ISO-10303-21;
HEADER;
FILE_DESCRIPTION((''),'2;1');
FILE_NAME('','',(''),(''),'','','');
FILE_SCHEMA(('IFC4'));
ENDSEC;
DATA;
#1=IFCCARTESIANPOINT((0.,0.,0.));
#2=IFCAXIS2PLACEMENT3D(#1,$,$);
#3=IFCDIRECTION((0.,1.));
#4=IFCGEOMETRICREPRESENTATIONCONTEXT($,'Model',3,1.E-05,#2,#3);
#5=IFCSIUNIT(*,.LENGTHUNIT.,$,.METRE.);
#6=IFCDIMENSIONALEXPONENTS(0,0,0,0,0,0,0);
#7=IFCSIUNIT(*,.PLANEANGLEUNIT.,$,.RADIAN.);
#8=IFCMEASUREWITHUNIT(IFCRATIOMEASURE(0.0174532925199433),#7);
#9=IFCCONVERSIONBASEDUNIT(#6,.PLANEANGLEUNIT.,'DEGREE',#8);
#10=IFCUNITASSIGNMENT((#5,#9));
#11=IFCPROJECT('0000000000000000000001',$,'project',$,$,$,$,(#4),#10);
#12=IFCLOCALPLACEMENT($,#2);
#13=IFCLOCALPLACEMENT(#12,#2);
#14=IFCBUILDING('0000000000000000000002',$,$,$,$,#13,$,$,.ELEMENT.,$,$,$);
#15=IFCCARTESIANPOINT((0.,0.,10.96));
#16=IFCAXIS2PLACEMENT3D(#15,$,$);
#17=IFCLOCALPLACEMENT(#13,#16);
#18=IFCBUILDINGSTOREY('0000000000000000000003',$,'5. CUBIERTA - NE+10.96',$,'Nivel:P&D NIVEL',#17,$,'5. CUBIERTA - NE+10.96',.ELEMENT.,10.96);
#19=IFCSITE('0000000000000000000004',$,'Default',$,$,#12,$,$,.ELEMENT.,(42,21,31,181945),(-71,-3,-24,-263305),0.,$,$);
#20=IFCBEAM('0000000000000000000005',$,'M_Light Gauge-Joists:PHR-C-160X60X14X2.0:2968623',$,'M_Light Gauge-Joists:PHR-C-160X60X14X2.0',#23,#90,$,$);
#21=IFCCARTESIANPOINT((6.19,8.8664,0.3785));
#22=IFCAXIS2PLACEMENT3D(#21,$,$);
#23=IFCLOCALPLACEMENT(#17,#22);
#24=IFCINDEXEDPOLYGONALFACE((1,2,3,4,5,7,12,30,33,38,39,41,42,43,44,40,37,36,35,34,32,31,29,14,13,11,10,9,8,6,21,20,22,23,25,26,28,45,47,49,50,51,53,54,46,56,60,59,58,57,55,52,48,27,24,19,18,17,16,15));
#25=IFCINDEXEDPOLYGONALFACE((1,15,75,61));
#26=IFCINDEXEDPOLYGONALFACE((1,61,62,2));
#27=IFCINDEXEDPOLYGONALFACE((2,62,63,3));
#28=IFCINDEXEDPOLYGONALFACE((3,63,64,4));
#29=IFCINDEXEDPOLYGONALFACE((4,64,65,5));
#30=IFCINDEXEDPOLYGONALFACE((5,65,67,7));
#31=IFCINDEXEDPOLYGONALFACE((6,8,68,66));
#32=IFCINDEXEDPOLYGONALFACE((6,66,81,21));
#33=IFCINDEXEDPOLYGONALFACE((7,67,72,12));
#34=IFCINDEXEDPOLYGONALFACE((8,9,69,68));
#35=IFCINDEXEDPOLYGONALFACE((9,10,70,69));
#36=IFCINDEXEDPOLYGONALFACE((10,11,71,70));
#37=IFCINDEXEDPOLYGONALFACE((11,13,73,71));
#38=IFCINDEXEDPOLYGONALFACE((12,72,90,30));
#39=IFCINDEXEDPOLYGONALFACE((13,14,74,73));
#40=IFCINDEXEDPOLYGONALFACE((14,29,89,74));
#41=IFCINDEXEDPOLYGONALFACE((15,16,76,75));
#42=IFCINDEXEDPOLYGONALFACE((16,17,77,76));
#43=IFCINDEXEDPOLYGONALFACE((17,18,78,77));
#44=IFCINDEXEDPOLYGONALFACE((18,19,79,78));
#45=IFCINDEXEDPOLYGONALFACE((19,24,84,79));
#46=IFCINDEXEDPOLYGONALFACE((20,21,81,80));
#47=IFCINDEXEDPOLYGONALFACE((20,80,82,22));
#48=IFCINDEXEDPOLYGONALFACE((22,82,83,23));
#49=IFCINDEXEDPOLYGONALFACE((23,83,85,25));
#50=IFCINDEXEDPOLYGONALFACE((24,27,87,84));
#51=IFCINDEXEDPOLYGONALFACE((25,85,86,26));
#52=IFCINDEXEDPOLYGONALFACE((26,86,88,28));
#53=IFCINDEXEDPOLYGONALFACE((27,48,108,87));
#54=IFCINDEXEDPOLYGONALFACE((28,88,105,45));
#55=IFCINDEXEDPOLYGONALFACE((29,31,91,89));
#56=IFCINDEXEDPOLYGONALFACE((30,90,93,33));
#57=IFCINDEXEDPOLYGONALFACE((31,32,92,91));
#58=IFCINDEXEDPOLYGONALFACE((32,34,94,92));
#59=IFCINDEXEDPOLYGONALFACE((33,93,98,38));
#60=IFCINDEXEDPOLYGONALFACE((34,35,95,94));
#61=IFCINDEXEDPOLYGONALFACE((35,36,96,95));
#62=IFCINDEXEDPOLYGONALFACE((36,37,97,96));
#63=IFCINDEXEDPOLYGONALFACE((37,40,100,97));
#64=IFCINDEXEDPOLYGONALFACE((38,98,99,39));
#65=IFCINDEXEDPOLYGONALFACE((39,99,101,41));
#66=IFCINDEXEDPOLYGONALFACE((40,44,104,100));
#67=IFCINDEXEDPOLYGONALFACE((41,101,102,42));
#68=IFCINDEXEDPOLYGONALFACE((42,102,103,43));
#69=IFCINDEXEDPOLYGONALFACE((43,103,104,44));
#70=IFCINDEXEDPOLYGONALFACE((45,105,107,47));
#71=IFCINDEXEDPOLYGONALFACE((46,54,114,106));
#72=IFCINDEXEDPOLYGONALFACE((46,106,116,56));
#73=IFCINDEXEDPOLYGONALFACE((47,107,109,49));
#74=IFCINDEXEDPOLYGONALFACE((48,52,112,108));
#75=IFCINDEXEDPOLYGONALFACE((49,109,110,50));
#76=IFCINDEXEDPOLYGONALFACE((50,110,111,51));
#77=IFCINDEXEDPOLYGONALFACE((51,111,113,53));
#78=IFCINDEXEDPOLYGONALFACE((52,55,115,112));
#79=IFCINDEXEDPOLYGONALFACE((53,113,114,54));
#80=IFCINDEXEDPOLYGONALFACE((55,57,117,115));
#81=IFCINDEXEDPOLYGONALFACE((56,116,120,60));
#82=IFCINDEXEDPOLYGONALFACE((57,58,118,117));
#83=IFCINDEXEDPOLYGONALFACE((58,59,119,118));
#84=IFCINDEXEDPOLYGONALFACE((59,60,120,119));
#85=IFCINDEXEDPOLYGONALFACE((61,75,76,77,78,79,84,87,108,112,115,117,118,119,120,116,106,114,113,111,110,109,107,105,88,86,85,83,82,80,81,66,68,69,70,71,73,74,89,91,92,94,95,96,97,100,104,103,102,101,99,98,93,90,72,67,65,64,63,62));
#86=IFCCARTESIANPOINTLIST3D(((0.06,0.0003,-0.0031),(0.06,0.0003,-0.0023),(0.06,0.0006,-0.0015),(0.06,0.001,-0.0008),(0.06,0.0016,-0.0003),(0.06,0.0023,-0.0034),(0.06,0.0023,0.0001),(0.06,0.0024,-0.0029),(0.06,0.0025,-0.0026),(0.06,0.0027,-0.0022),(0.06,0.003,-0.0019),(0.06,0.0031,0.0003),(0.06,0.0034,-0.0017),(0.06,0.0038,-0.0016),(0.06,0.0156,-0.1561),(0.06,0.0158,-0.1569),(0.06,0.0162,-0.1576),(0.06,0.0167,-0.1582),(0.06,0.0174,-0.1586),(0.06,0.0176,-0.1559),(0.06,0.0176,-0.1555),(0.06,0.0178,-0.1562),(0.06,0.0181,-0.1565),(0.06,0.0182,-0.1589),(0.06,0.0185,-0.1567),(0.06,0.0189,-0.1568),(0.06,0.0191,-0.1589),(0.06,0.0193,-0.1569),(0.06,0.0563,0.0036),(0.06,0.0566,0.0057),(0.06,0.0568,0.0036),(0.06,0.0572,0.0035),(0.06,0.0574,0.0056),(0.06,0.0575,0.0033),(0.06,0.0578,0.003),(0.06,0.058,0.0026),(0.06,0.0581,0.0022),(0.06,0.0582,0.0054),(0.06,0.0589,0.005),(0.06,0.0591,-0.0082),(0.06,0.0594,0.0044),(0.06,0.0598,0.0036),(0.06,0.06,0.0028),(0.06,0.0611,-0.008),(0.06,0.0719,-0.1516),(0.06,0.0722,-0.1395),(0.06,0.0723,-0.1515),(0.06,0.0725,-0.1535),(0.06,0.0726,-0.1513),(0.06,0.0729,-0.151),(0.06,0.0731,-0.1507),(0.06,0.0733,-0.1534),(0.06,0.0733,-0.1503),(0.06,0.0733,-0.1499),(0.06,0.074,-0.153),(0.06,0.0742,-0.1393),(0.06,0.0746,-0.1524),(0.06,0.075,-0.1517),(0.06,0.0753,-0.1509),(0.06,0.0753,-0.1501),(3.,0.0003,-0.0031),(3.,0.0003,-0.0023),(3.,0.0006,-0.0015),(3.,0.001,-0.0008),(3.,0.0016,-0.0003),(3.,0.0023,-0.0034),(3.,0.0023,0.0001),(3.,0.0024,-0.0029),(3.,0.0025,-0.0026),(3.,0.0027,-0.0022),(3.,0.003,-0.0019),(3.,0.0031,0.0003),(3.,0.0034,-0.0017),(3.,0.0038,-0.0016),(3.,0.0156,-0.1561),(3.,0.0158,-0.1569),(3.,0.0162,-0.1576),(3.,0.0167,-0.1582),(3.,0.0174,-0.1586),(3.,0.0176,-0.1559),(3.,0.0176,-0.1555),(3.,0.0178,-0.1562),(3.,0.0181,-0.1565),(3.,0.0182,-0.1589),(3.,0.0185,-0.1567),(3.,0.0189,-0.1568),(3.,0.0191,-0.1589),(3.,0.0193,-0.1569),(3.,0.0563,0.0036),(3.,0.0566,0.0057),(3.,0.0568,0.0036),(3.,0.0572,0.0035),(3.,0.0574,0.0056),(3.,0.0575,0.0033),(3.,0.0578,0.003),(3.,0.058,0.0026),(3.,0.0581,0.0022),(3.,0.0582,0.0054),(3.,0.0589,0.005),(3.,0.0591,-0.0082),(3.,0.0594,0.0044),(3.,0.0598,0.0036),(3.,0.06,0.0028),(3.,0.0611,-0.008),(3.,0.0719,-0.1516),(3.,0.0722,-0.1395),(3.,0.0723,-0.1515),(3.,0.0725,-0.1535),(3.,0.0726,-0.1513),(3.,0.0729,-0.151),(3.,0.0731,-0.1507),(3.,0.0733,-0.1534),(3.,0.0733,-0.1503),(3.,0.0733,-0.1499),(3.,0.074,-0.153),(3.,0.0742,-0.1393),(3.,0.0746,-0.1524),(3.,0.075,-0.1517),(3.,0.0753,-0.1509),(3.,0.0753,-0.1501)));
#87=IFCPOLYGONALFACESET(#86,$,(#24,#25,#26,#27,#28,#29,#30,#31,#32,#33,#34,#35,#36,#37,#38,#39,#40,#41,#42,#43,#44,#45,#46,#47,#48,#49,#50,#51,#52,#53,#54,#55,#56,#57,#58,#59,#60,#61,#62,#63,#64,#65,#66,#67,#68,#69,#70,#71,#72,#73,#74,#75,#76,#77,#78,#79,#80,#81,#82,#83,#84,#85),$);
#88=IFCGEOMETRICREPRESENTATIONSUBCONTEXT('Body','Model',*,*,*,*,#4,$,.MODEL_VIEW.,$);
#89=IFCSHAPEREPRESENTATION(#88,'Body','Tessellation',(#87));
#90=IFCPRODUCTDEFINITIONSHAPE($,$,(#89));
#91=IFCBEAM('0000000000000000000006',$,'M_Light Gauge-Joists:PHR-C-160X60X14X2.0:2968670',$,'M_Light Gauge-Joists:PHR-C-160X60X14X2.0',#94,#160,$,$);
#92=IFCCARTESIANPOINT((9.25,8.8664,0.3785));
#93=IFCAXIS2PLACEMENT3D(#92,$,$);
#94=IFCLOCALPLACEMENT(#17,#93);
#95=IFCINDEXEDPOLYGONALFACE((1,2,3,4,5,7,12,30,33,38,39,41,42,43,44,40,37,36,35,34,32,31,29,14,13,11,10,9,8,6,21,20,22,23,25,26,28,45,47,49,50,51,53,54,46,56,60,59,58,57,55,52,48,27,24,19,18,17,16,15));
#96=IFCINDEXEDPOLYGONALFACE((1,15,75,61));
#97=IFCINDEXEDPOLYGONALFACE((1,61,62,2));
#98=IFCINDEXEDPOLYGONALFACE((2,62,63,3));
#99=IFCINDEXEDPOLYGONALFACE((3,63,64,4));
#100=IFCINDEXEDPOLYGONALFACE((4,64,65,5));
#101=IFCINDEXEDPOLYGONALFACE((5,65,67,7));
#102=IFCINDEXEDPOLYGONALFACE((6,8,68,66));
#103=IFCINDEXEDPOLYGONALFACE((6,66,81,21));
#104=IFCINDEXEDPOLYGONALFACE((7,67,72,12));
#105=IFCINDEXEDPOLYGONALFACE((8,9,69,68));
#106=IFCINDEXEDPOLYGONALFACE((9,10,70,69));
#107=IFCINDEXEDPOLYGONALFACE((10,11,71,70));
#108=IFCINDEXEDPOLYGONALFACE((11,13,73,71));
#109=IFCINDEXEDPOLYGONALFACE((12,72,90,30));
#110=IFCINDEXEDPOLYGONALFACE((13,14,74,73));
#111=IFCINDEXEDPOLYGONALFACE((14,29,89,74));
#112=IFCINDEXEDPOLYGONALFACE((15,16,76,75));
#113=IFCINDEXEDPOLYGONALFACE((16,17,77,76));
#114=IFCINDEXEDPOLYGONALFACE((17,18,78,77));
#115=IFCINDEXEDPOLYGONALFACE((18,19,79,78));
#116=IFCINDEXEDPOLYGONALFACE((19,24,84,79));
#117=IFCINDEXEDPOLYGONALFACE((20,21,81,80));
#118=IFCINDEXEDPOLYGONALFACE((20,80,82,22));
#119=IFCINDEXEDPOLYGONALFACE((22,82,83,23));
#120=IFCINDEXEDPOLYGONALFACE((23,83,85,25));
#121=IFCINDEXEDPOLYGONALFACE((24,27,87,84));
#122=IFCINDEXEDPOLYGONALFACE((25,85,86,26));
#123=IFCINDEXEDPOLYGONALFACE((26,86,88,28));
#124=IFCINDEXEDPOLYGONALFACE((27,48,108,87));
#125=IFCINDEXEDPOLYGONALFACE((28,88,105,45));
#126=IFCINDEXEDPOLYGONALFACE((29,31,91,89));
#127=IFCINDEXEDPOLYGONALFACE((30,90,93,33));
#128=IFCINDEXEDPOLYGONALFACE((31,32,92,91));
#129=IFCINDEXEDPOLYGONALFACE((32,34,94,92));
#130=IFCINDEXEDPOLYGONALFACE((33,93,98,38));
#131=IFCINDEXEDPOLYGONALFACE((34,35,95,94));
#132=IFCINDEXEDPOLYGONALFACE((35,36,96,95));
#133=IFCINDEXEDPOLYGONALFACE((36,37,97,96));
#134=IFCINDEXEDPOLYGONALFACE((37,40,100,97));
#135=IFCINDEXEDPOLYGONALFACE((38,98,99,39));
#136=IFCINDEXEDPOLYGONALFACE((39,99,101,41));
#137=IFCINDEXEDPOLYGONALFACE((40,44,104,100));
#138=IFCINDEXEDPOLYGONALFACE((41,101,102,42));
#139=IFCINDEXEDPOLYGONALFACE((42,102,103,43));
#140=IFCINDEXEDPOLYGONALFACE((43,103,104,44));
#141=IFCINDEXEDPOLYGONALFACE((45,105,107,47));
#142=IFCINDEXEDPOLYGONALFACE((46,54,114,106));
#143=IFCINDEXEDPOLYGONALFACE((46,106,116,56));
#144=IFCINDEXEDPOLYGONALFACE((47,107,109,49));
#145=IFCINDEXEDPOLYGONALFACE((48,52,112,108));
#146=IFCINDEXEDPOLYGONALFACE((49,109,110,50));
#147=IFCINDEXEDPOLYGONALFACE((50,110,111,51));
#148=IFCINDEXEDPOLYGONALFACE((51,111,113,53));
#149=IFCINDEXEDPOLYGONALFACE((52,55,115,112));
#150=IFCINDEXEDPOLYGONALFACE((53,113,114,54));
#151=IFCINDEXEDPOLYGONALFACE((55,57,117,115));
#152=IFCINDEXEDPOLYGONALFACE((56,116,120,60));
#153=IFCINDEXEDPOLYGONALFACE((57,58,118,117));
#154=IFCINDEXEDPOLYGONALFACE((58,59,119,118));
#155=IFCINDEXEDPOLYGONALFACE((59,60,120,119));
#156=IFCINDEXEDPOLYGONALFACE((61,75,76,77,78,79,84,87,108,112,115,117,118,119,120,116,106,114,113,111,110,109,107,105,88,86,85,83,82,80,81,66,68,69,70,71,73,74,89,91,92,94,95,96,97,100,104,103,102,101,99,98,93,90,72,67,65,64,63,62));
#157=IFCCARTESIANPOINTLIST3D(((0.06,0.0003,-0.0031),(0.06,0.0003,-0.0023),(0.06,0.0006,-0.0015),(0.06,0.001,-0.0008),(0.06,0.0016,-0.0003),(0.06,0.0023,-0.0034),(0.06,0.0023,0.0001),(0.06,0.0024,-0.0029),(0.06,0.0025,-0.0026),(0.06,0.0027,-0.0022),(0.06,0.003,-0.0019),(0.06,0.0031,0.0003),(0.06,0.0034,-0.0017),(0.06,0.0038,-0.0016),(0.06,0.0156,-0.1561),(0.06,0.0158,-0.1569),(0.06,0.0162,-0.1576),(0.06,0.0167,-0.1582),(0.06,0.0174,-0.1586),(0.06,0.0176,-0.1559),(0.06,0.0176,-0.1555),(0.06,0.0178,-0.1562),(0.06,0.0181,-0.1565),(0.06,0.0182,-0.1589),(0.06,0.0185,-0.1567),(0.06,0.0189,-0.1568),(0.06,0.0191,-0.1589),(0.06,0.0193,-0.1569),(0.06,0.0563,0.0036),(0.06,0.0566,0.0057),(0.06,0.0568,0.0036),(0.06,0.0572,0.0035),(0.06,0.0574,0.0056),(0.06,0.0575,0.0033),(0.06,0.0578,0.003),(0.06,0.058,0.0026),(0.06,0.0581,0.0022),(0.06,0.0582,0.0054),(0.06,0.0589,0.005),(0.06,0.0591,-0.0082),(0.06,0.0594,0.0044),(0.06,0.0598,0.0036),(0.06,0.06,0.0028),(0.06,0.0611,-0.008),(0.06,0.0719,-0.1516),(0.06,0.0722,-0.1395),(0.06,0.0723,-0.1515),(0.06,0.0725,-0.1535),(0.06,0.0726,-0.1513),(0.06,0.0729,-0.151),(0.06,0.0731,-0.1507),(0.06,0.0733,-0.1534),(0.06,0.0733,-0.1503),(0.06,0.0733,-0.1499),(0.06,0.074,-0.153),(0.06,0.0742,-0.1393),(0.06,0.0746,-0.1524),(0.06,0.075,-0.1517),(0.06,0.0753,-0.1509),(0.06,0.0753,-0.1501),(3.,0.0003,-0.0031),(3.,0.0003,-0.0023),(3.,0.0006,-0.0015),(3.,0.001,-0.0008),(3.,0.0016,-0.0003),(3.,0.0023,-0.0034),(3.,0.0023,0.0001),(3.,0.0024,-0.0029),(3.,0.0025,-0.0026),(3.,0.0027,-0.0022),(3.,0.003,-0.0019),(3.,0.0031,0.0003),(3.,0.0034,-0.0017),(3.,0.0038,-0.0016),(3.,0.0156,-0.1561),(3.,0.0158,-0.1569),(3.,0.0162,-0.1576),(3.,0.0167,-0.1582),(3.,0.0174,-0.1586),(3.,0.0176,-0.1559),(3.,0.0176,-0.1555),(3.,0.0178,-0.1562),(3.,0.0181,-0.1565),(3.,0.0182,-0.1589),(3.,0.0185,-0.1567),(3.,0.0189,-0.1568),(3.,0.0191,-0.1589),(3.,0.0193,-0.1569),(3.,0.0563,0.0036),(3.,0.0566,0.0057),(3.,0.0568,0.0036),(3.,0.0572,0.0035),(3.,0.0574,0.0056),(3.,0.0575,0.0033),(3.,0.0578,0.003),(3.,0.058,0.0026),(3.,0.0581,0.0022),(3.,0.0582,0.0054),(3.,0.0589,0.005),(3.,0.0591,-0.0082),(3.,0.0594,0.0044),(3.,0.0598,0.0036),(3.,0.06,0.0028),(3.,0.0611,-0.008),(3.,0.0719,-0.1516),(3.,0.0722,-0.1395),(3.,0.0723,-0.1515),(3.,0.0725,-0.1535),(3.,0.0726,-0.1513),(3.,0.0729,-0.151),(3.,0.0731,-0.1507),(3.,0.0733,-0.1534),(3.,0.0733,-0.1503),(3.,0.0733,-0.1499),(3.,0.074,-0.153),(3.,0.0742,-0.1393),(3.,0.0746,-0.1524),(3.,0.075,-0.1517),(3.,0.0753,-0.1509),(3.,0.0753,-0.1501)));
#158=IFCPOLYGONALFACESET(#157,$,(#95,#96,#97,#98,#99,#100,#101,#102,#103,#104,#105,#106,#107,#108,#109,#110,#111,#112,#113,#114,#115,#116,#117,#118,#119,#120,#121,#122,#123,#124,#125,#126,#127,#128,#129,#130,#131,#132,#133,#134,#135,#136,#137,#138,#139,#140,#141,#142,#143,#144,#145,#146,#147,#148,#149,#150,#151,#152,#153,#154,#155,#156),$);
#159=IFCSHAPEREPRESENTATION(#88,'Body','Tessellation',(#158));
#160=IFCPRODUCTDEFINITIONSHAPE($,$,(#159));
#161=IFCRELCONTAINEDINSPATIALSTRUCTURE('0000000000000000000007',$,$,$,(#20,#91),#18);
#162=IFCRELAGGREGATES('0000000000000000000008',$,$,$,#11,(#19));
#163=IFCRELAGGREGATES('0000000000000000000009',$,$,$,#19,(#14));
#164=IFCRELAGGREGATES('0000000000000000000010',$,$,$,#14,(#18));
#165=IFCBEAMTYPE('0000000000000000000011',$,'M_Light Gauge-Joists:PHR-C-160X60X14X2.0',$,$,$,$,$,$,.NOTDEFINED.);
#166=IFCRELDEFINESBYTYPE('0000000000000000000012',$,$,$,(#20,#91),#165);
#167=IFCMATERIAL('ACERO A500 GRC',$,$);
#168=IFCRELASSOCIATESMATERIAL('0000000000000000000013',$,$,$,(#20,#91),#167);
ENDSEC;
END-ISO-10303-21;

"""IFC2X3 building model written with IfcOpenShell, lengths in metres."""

from ifc_helpers import new_model, entity, si_unit, converted_unit, direction, frame, frame_2d, origin, place, context, subcontext, project, spatial, polyline, circle_curve, parameter, trimmed, segment, composite_curve, outline, extrude, material, type_object, element, save


model = new_model("IFC2X3")

# Units and contexts
model_context = context("Model", 3, precision=1e-05, world=origin(), true_north=direction((0.0, 1.0)))
body_context = subcontext(model_context, "Body", "Model", "MODEL_VIEW")
ifc_project = project(units=[si_unit("LENGTHUNIT", "METRE"), converted_unit("PLANEANGLEUNIT", "DEGREE", entity("IfcRatioMeasure", 0.0174532925199433), si_unit("PLANEANGLEUNIT", "RADIAN"), dimensions=[0, 0, 0, 0, 0, 0, 0])], contexts=[model_context])

# Site, building, storey
site_placement = place(None, origin())
site = spatial("IfcSite", under=ifc_project, at=site_placement, Name="Default", CompositionType="ELEMENT", RefLatitude=(42, 21, 31, 181945), RefLongitude=(-71, -3, -24, -263305), RefElevation=0.0)
building_placement = place(site_placement, origin())
building = spatial("IfcBuilding", under=site, at=building_placement, CompositionType="ELEMENT")
storey_placement = place(building_placement, frame((0.0, 0.0, 10.96)))
storey = spatial("IfcBuildingStorey", under=building, at=storey_placement, Name="5. CUBIERTA - NE+10.96", ObjectType="Nivel:P&D NIVEL", LongName="5. CUBIERTA - NE+10.96", CompositionType="ELEMENT", Elevation=10.96)

# Beams
ifc_material_1 = material(Name="ACERO A500 GRC")
beam_type_1 = type_object("IfcBeamType", Name="M_Light Gauge-Joists:PHR-C-160X60X14X2.0", PredefinedType="NOTDEFINED")
beam_1_placement = place(storey_placement, frame((6.19, 8.8664, 0.3785)))
element("IfcBeam", 1, at=beam_1_placement, inside=storey, type_object=beam_type_1, material=ifc_material_1, Name="M_Light Gauge-Joists:PHR-C-160X60X14X2.0:2968623", ObjectType="M_Light Gauge-Joists:PHR-C-160X60X14X2.0", context=body_context, shape_type="SweptSolid", body=[
    extrude(outline(composite_curve([segment(trimmed(circle_curve(frame_2d((-0.0764, -0.0322), x_axis=(-1.0, 0.0)), 0.0016), [parameter(0.0)], [parameter(90.0)], True, "PARAMETER"), False, "CONTINUOUS"), segment(polyline([(-0.078, -0.0322), (-0.078, 0.0206)]), True, "CONTINUOUS"), segment(trimmed(circle_curve(frame_2d((-0.0764, 0.0206), x_axis=(0.0, 1.0)), 0.0016), [parameter(0.0)], [parameter(90.0)], True, "PARAMETER"), False, "CONTINUOUS"), segment(polyline([(-0.0764, 0.0222), (-0.066, 0.0222)]), True, "CONTINUOUS"), segment(polyline([(-0.066, 0.0222), (-0.066, 0.0242)]), True, "CONTINUOUS"), segment(polyline([(-0.066, 0.0242), (-0.0768, 0.0242)]), True, "CONTINUOUS"), segment(trimmed(circle_curve(frame_2d((-0.0768, 0.021), x_axis=(-1.0, 0.0)), 0.0032), [parameter(270.0)], [parameter(0.0)], True, "PARAMETER"), True, "CONTINUOUS"), segment(polyline([(-0.08, 0.021), (-0.08, -0.0326)]), True, "CONTINUOUS"), segment(trimmed(circle_curve(frame_2d((-0.0768, -0.0326), x_axis=(0.0, -1.0)), 0.0032), [parameter(270.0)], [parameter(0.0)], True, "PARAMETER"), True, "CONTINUOUS"), segment(polyline([(-0.0768, -0.0358), (0.0768, -0.0358)]), True, "CONTINUOUS"), segment(trimmed(circle_curve(frame_2d((0.0768, -0.0326), x_axis=(1.0, 0.0)), 0.0032), [parameter(270.0)], [parameter(0.0)], True, "PARAMETER"), True, "CONTINUOUS"), segment(polyline([(0.08, -0.0326), (0.08, 0.021)]), True, "CONTINUOUS"), segment(trimmed(circle_curve(frame_2d((0.0768, 0.021), x_axis=(0.0, 1.0)), 0.0032), [parameter(270.0)], [parameter(0.0)], True, "PARAMETER"), True, "CONTINUOUS"), segment(polyline([(0.0768, 0.0242), (0.066, 0.0242)]), True, "CONTINUOUS"), segment(polyline([(0.066, 0.0242), (0.066, 0.0222)]), True, "CONTINUOUS"), segment(polyline([(0.066, 0.0222), (0.0764, 0.0222)]), True, "CONTINUOUS"), segment(trimmed(circle_curve(frame_2d((0.0764, 0.0206), x_axis=(1.0, 0.0)), 0.0016), [parameter(0.0)], [parameter(90.0)], True, "PARAMETER"), False, "CONTINUOUS"), segment(polyline([(0.078, 0.0206), (0.078, -0.0322)]), True, "CONTINUOUS"), segment(trimmed(circle_curve(frame_2d((0.0764, -0.0322), x_axis=(0.0, -1.0)), 0.0016), [parameter(0.0)], [parameter(90.0)], True, "PARAMETER"), False, "CONTINUOUS"), segment(polyline([(0.0764, -0.0338), (-0.0764, -0.0338)]), True, "CONTINUOUS")], self_intersect=False)), frame((0.06, 0.0436, -0.076), z_axis=(-1.0, 0.0, 0.0), x_axis=(0.0, -0.099504, 0.995037)), (0.0, 0.0, -1.0), 2.94),
])
beam_2_placement = place(storey_placement, frame((9.25, 8.8664, 0.3785)))
element("IfcBeam", 2, at=beam_2_placement, inside=storey, type_object=beam_type_1, material=ifc_material_1, Name="M_Light Gauge-Joists:PHR-C-160X60X14X2.0:2968670", ObjectType="M_Light Gauge-Joists:PHR-C-160X60X14X2.0", context=body_context, shape_type="SweptSolid", body=[
    extrude(outline(composite_curve([segment(trimmed(circle_curve(frame_2d((-0.0764, -0.0322), x_axis=(-1.0, 0.0)), 0.0016), [parameter(0.0)], [parameter(90.0)], True, "PARAMETER"), False, "CONTINUOUS"), segment(polyline([(-0.078, -0.0322), (-0.078, 0.0206)]), True, "CONTINUOUS"), segment(trimmed(circle_curve(frame_2d((-0.0764, 0.0206), x_axis=(0.0, 1.0)), 0.0016), [parameter(0.0)], [parameter(90.0)], True, "PARAMETER"), False, "CONTINUOUS"), segment(polyline([(-0.0764, 0.0222), (-0.066, 0.0222)]), True, "CONTINUOUS"), segment(polyline([(-0.066, 0.0222), (-0.066, 0.0242)]), True, "CONTINUOUS"), segment(polyline([(-0.066, 0.0242), (-0.0768, 0.0242)]), True, "CONTINUOUS"), segment(trimmed(circle_curve(frame_2d((-0.0768, 0.021), x_axis=(-1.0, 0.0)), 0.0032), [parameter(270.0)], [parameter(0.0)], True, "PARAMETER"), True, "CONTINUOUS"), segment(polyline([(-0.08, 0.021), (-0.08, -0.0326)]), True, "CONTINUOUS"), segment(trimmed(circle_curve(frame_2d((-0.0768, -0.0326), x_axis=(0.0, -1.0)), 0.0032), [parameter(270.0)], [parameter(0.0)], True, "PARAMETER"), True, "CONTINUOUS"), segment(polyline([(-0.0768, -0.0358), (0.0768, -0.0358)]), True, "CONTINUOUS"), segment(trimmed(circle_curve(frame_2d((0.0768, -0.0326), x_axis=(1.0, 0.0)), 0.0032), [parameter(270.0)], [parameter(0.0)], True, "PARAMETER"), True, "CONTINUOUS"), segment(polyline([(0.08, -0.0326), (0.08, 0.021)]), True, "CONTINUOUS"), segment(trimmed(circle_curve(frame_2d((0.0768, 0.021), x_axis=(0.0, 1.0)), 0.0032), [parameter(270.0)], [parameter(0.0)], True, "PARAMETER"), True, "CONTINUOUS"), segment(polyline([(0.0768, 0.0242), (0.066, 0.0242)]), True, "CONTINUOUS"), segment(polyline([(0.066, 0.0242), (0.066, 0.0222)]), True, "CONTINUOUS"), segment(polyline([(0.066, 0.0222), (0.0764, 0.0222)]), True, "CONTINUOUS"), segment(trimmed(circle_curve(frame_2d((0.0764, 0.0206), x_axis=(1.0, 0.0)), 0.0016), [parameter(0.0)], [parameter(90.0)], True, "PARAMETER"), False, "CONTINUOUS"), segment(polyline([(0.078, 0.0206), (0.078, -0.0322)]), True, "CONTINUOUS"), segment(trimmed(circle_curve(frame_2d((0.0764, -0.0322), x_axis=(0.0, -1.0)), 0.0016), [parameter(0.0)], [parameter(90.0)], True, "PARAMETER"), False, "CONTINUOUS"), segment(polyline([(0.0764, -0.0338), (-0.0764, -0.0338)]), True, "CONTINUOUS")], self_intersect=False)), frame((0.06, 0.0436, -0.076), z_axis=(-1.0, 0.0, 0.0), x_axis=(0.0, -0.099504, 0.995037)), (0.0, 0.0, -1.0), 2.94),
])

save(model, "model.ifc")
